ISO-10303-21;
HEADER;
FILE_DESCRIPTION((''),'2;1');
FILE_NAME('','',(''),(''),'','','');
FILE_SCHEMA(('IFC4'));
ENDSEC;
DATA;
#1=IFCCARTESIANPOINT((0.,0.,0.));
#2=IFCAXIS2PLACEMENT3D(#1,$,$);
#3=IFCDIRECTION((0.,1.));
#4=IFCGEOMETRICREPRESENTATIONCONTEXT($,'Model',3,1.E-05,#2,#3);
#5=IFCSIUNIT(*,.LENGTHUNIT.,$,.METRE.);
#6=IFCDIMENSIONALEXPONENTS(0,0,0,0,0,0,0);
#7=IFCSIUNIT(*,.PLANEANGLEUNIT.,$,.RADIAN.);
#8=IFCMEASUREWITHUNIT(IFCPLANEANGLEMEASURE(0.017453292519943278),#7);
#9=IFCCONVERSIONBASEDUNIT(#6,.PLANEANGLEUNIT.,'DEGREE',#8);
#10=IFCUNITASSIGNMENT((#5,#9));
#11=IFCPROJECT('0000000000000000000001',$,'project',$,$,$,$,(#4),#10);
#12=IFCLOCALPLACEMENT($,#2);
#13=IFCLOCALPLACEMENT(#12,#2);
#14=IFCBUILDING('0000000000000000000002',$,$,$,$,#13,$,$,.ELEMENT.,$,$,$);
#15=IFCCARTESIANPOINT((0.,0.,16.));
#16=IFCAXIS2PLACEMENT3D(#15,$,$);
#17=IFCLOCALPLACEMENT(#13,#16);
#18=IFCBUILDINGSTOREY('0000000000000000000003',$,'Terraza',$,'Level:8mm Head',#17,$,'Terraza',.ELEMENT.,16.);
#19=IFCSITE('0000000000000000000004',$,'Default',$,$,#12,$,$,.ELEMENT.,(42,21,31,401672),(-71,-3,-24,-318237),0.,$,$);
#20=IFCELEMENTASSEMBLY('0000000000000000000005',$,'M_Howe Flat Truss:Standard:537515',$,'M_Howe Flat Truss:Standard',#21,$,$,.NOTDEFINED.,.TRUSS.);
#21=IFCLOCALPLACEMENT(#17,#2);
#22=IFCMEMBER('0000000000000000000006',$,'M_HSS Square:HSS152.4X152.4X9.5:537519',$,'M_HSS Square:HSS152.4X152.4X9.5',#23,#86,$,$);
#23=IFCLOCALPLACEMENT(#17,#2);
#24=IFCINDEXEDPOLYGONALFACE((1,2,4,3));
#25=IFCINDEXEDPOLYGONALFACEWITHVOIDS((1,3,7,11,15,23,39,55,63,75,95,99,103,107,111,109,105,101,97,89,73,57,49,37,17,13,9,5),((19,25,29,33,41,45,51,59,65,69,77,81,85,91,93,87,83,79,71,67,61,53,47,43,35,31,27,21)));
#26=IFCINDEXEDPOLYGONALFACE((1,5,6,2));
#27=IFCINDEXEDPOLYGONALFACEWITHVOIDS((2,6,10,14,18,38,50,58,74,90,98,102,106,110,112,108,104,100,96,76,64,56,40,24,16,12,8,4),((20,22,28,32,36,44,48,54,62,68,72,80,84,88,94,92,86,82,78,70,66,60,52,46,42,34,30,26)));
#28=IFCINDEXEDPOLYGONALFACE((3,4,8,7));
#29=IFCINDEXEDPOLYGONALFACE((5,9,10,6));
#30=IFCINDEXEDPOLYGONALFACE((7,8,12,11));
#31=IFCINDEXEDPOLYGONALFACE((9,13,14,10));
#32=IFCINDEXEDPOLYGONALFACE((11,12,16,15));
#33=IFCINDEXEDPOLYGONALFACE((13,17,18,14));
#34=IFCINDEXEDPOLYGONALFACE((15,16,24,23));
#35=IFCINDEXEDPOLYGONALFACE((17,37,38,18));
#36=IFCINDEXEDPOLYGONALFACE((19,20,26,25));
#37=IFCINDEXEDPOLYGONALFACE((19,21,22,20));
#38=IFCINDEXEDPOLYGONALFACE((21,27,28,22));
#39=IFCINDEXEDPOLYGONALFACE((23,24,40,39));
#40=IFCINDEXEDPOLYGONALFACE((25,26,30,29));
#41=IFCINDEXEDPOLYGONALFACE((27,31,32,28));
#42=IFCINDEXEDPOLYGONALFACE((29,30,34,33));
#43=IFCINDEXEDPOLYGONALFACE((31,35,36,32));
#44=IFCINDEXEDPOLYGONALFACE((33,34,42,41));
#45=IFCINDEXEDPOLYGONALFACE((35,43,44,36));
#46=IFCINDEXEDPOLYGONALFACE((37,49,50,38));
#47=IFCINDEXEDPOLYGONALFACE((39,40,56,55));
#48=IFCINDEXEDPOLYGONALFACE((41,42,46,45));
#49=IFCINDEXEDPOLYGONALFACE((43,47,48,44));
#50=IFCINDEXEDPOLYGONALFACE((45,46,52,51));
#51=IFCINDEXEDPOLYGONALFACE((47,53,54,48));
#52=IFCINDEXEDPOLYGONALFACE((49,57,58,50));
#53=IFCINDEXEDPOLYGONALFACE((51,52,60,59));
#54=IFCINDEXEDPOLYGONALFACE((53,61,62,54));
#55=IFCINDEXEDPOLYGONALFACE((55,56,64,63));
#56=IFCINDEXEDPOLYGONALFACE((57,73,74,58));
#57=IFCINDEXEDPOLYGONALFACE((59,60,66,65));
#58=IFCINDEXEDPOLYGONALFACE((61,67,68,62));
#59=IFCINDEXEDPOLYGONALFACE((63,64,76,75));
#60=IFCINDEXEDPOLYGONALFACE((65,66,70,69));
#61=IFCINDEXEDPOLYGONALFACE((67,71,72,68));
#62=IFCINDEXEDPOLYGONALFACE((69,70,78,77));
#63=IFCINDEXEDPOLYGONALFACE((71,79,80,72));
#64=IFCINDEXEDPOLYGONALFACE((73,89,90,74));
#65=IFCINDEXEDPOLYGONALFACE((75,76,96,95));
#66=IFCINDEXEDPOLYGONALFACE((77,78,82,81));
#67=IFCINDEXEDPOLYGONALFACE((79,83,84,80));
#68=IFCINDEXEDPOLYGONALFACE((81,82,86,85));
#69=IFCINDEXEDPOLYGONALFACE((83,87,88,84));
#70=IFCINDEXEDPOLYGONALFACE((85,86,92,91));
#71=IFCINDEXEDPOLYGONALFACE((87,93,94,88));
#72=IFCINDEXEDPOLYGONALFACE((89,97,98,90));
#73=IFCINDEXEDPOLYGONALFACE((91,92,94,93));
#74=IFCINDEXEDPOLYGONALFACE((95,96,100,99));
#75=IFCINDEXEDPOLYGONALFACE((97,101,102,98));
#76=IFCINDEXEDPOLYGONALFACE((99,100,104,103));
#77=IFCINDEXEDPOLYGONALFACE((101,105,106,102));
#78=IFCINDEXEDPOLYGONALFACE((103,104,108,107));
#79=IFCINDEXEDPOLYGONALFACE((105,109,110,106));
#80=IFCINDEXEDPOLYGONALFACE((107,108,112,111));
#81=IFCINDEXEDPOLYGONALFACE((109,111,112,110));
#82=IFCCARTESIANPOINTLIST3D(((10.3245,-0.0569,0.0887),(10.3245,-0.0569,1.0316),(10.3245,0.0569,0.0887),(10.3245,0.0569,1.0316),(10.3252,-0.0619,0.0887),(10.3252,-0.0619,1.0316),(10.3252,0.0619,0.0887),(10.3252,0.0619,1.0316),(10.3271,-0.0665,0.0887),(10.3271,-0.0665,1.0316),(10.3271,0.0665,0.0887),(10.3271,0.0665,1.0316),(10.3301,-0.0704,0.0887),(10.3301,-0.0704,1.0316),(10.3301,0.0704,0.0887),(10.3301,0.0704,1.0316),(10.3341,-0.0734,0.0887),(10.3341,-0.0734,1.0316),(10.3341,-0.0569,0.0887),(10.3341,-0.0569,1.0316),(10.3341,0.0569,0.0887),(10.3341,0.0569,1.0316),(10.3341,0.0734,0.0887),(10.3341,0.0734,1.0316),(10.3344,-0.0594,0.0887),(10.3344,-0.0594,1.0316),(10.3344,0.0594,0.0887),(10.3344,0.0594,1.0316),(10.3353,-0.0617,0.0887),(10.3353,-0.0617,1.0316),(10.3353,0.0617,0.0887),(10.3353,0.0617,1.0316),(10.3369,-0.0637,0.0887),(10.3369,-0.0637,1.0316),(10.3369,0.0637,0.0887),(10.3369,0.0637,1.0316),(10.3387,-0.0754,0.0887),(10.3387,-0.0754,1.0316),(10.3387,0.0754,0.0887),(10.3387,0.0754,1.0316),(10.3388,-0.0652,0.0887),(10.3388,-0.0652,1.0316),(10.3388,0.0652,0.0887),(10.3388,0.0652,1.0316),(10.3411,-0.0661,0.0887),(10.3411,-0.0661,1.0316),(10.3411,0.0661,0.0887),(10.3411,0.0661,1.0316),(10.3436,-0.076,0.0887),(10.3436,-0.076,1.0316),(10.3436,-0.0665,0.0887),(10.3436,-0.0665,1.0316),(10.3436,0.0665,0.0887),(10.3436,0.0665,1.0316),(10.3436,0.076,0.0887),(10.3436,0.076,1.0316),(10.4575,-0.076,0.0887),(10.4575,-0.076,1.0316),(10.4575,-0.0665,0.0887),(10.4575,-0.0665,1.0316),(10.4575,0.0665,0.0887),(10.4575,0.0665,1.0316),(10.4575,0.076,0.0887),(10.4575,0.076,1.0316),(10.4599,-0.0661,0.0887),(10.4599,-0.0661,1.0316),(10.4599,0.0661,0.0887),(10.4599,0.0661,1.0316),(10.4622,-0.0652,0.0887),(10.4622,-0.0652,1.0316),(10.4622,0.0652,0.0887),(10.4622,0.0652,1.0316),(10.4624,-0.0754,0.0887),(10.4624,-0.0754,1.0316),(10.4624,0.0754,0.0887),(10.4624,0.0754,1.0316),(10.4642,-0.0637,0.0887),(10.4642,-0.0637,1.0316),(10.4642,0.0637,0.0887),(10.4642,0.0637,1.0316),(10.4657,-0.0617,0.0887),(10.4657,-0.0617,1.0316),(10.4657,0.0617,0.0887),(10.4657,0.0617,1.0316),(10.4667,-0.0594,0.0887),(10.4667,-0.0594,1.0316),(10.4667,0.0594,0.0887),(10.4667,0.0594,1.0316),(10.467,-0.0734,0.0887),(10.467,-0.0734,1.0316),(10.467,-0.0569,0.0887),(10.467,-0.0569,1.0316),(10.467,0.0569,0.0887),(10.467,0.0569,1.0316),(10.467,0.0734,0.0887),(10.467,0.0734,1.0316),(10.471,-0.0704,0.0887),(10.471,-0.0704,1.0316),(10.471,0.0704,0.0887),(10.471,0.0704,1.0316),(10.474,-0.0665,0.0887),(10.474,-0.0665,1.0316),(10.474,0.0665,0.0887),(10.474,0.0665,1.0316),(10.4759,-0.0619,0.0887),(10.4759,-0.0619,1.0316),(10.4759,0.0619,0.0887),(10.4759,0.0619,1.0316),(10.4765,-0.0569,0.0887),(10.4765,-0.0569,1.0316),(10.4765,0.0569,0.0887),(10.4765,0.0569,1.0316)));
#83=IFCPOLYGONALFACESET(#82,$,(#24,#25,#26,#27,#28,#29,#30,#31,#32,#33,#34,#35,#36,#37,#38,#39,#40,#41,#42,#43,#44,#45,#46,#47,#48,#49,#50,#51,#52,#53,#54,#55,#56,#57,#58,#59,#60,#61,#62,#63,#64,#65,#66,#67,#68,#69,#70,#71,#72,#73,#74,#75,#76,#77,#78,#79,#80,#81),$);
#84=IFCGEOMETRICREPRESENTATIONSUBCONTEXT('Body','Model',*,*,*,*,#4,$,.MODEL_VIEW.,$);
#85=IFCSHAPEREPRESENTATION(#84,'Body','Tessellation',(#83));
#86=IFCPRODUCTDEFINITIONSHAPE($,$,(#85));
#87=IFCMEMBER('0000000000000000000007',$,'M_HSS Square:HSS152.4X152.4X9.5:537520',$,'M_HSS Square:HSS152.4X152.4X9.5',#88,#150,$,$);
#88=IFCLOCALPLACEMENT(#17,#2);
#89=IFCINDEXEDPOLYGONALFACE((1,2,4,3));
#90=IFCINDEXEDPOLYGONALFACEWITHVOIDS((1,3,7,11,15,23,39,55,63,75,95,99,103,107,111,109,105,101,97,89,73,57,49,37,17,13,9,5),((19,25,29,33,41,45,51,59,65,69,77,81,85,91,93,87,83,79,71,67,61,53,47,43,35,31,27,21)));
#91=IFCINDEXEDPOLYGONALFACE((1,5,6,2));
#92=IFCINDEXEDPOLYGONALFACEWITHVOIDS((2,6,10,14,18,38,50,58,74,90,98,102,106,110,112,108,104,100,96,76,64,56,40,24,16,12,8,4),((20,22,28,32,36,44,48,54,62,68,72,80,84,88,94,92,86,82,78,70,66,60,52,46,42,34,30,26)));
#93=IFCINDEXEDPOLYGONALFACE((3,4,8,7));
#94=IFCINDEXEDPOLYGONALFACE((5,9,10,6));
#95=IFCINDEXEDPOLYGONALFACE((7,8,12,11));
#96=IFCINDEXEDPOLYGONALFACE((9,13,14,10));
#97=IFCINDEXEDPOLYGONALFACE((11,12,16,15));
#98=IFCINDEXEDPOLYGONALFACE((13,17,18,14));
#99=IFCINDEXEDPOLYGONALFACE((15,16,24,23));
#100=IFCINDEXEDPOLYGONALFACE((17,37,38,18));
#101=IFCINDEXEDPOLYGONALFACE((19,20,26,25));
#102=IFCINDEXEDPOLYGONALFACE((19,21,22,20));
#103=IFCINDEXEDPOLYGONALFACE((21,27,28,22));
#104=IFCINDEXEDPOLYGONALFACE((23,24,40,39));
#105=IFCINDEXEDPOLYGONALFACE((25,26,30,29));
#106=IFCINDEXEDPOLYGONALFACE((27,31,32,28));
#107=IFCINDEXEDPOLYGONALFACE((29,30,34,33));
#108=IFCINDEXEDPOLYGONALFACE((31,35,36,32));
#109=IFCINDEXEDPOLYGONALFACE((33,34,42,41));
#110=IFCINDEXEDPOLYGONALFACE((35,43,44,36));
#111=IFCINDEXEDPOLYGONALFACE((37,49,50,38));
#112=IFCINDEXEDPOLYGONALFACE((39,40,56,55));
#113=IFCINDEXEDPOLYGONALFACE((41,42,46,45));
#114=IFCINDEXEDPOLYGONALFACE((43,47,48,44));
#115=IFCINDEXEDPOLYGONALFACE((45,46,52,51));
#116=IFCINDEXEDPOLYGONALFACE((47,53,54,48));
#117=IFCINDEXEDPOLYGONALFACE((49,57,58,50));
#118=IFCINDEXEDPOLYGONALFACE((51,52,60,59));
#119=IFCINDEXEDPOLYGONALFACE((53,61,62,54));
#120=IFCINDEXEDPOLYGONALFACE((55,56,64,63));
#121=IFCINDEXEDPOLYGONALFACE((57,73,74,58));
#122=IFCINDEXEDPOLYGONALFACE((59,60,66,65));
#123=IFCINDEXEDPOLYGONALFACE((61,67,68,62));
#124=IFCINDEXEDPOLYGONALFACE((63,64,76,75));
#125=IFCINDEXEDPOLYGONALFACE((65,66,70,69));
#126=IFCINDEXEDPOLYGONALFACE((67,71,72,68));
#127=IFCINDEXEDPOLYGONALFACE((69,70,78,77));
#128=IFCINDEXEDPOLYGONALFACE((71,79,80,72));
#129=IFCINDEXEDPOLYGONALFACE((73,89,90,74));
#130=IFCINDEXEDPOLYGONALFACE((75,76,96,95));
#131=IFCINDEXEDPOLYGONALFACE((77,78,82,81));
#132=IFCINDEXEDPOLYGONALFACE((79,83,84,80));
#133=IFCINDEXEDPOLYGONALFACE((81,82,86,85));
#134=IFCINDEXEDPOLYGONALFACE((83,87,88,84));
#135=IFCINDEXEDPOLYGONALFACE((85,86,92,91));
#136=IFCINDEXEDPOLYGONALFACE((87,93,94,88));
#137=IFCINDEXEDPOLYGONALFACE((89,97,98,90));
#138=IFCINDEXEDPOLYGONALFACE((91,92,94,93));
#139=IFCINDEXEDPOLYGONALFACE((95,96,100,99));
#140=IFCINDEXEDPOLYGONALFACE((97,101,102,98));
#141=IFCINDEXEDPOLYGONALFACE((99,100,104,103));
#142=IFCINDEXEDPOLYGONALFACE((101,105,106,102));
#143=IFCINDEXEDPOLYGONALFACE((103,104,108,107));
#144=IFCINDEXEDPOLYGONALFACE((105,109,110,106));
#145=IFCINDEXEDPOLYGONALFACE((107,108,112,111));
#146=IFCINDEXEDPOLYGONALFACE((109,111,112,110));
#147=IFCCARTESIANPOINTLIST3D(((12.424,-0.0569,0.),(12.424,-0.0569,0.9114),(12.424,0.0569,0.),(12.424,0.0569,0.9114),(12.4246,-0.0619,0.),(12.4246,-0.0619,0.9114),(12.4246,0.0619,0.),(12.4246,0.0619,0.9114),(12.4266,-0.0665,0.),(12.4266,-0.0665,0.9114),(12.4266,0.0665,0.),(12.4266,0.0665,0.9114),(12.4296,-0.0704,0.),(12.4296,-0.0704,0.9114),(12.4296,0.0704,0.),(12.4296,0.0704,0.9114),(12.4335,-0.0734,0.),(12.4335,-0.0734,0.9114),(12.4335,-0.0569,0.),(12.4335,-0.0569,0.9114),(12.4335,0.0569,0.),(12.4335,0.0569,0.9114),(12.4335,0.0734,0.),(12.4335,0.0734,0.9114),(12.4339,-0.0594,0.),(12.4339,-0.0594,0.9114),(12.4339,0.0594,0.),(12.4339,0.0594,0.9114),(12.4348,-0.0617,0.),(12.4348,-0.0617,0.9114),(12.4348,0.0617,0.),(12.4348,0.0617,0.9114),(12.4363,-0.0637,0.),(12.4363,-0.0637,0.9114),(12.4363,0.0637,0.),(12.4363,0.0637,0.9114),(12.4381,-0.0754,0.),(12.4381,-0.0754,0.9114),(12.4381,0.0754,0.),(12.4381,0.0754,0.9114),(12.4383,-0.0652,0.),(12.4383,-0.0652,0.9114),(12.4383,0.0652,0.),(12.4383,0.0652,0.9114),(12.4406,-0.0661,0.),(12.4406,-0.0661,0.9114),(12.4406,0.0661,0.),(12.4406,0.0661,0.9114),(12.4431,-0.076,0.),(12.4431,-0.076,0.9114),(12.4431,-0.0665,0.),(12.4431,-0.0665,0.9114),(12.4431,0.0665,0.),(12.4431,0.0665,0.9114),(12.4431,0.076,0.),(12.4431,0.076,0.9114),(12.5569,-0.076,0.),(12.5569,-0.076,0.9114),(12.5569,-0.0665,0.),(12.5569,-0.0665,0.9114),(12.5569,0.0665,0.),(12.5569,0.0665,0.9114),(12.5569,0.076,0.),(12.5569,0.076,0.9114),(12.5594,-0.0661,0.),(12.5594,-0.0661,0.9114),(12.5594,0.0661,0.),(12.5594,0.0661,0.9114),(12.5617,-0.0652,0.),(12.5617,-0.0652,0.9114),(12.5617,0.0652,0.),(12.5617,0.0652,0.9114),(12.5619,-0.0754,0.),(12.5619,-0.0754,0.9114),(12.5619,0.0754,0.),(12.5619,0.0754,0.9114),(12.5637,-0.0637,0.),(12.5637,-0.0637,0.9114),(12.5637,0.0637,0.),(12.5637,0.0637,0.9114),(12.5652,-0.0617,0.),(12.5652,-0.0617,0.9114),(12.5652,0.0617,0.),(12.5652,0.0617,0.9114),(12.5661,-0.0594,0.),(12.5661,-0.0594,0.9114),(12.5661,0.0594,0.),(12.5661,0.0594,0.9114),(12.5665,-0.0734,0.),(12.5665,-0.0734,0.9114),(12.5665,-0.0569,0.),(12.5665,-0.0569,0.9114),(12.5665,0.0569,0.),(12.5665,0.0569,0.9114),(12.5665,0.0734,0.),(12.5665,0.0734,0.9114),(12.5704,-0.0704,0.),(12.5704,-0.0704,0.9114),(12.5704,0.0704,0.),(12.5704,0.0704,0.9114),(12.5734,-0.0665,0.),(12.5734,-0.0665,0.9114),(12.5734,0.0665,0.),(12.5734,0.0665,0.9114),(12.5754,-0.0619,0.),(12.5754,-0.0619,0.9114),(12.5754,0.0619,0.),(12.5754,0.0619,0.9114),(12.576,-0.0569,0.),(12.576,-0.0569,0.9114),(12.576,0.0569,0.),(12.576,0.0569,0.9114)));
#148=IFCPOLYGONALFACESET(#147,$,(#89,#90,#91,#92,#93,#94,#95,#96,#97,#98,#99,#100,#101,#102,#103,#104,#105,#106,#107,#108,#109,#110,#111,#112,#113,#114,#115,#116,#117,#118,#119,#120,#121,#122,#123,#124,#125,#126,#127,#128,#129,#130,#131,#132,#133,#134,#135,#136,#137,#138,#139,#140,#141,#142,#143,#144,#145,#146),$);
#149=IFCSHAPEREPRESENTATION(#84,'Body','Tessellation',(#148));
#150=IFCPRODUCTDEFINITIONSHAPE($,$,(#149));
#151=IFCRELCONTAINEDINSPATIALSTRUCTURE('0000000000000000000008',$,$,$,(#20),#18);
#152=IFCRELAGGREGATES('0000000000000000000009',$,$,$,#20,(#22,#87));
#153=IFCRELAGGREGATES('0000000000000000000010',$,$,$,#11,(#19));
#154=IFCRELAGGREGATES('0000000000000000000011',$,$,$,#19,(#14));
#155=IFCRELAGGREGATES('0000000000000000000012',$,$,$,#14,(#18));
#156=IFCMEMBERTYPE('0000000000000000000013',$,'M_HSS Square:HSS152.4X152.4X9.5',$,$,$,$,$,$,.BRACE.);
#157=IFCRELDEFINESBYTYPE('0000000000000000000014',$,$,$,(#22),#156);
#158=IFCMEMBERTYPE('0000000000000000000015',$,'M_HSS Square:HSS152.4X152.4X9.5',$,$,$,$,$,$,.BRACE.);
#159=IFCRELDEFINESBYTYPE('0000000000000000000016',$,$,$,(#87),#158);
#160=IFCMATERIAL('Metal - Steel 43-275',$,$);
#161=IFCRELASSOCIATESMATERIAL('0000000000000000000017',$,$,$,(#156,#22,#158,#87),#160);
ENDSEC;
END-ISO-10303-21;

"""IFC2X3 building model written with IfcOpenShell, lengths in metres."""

from ifc_helpers import new_model, entity, si_unit, converted_unit, direction, frame, frame_2d, origin, place, context, subcontext, project, spatial, polyline, circle_curve, parameter, trimmed, segment, composite_curve, outline, extrude, source, transform, mapped, material, type_object, type_shapes, element, aggregate, save


model = new_model("IFC2X3")

# Units and contexts
model_context = context("Model", 3, precision=1e-05, world=origin(), true_north=direction((0.0, 1.0)))
body_context = subcontext(model_context, "Body", "Model", "MODEL_VIEW")
ifc_project = project(units=[si_unit("LENGTHUNIT", "METRE"), converted_unit("PLANEANGLEUNIT", "DEGREE", entity("IfcPlaneAngleMeasure", 0.017453292519943278), si_unit("PLANEANGLEUNIT", "RADIAN"), dimensions=[0, 0, 0, 0, 0, 0, 0])], contexts=[model_context])

# Site, building, storey
site_placement = place(None, origin())
site = spatial("IfcSite", under=ifc_project, at=site_placement, Name="Default", CompositionType="ELEMENT", RefLatitude=(42, 21, 31, 401672), RefLongitude=(-71, -3, -24, -318237), RefElevation=0.0)
building_placement = place(site_placement, origin())
building = spatial("IfcBuilding", under=site, at=building_placement, CompositionType="ELEMENT")
storey_placement = place(building_placement, frame((0.0, 0.0, 16.0)))
storey = spatial("IfcBuildingStorey", under=building, at=storey_placement, Name="Terraza", ObjectType="Level:8mm Head", LongName="Terraza", CompositionType="ELEMENT", Elevation=16.0)

# Element assembly
assembly_1_placement = place(storey_placement, origin())
assembly_1 = element("IfcElementAssembly", 1, at=assembly_1_placement, inside=storey, Name="M_Howe Flat Truss:Standard:537515", ObjectType="M_Howe Flat Truss:Standard", AssemblyPlace="NOTDEFINED", PredefinedType="TRUSS")
ifc_material_1 = material(Name="Metal - Steel 43-275")

# Members
member_type_1 = type_object("IfcMemberType", Name="M_HSS Square:HSS152.4X152.4X9.5", PredefinedType="BRACE", material=ifc_material_1)
shared_shape_1 = source(origin(), body_context, "Body", "SweptSolid", [
    extrude(outline(composite_curve([segment(polyline([(-0.0569, -0.076), (0.0569, -0.076)]), True, "CONTINUOUS"), segment(trimmed(circle_curve(frame_2d((0.0569, -0.0569), x_axis=(0.0, 1.0)), 0.0191), [parameter(180.0)], [parameter(270.0)], True, "PARAMETER"), True, "CONTINUOUS"), segment(polyline([(0.076, -0.0569), (0.076, 0.0569)]), True, "CONTINUOUS"), segment(trimmed(circle_curve(frame_2d((0.0569, 0.0569), x_axis=(0.0, 1.0)), 0.0191), [parameter(270.0)], [parameter(0.0)], True, "PARAMETER"), True, "CONTINUOUS"), segment(polyline([(0.0569, 0.076), (-0.0569, 0.076)]), True, "CONTINUOUS"), segment(trimmed(circle_curve(frame_2d((-0.0569, 0.0569), x_axis=(0.0, 1.0)), 0.0191), [parameter(0.0)], [parameter(90.0)], True, "PARAMETER"), True, "CONTINUOUS"), segment(polyline([(-0.076, 0.0569), (-0.076, -0.0569)]), True, "CONTINUOUS"), segment(trimmed(circle_curve(frame_2d((-0.0569, -0.0569), x_axis=(0.0, 1.0)), 0.0191), [parameter(90.0)], [parameter(180.0)], True, "PARAMETER"), True, "CONTINUOUS")], self_intersect=False), holes=[composite_curve([segment(trimmed(circle_curve(frame_2d((-0.0569, 0.0569), x_axis=(0.0, 1.0)), 0.0095), [parameter(360.0)], [parameter(90.0)], True, "PARAMETER"), False, "CONTINUOUS"), segment(polyline([(-0.0569, 0.0665), (0.0569, 0.0665)]), True, "CONTINUOUS"), segment(trimmed(circle_curve(frame_2d((0.0569, 0.0569), x_axis=(0.0, 1.0)), 0.0095), [parameter(270.0)], [parameter(360.0)], True, "PARAMETER"), False, "CONTINUOUS"), segment(polyline([(0.0665, 0.0569), (0.0665, -0.0569)]), True, "CONTINUOUS"), segment(trimmed(circle_curve(frame_2d((0.0569, -0.0569), x_axis=(0.0, 1.0)), 0.0095), [parameter(180.0)], [parameter(270.0)], True, "PARAMETER"), False, "CONTINUOUS"), segment(polyline([(0.0569, -0.0665), (-0.0569, -0.0665)]), True, "CONTINUOUS"), segment(trimmed(circle_curve(frame_2d((-0.0569, -0.0569), x_axis=(0.0, 1.0)), 0.0095), [parameter(90.0)], [parameter(180.0)], True, "PARAMETER"), False, "CONTINUOUS"), segment(polyline([(-0.0665, -0.0569), (-0.0665, 0.0569)]), True, "CONTINUOUS")], self_intersect=False)]), frame((-0.4738, 0.0, 0.0), z_axis=(1.0, 0.0, 0.0), x_axis=(0.0, 0.0, -1.0)), (0.0, 0.0, 1.0), 0.9429),
])
type_shapes(member_type_1, [shared_shape_1])
member_1_placement = place(assembly_1_placement, frame((10.4005, 0.0, 0.5625), z_axis=(1.0, 0.0, 0.0), x_axis=(0.0, 0.0, 1.0)))
member_1 = element("IfcMember", 2, at=member_1_placement, type_object=member_type_1, material=ifc_material_1, Name="M_HSS Square:HSS152.4X152.4X9.5:537519", ObjectType="M_HSS Square:HSS152.4X152.4X9.5", context=body_context, shape_type="MappedRepresentation", body=[
    mapped(shared_shape_1, transform((0.0, 0.0, 0.0), scale=1.0)),
])
member_type_2 = type_object("IfcMemberType", Name="M_HSS Square:HSS152.4X152.4X9.5", PredefinedType="BRACE", material=ifc_material_1)
shared_shape_2 = source(origin(), body_context, "Body", "SweptSolid", [
    extrude(outline(composite_curve([segment(polyline([(-0.0569, -0.076), (0.0569, -0.076)]), True, "CONTINUOUS"), segment(trimmed(circle_curve(frame_2d((0.0569, -0.0569), x_axis=(0.0, 1.0)), 0.0191), [parameter(180.0)], [parameter(270.0)], True, "PARAMETER"), True, "CONTINUOUS"), segment(polyline([(0.076, -0.0569), (0.076, 0.0569)]), True, "CONTINUOUS"), segment(trimmed(circle_curve(frame_2d((0.0569, 0.0569), x_axis=(0.0, 1.0)), 0.0191), [parameter(270.0)], [parameter(0.0)], True, "PARAMETER"), True, "CONTINUOUS"), segment(polyline([(0.0569, 0.076), (-0.0569, 0.076)]), True, "CONTINUOUS"), segment(trimmed(circle_curve(frame_2d((-0.0569, 0.0569), x_axis=(0.0, 1.0)), 0.0191), [parameter(0.0)], [parameter(90.0)], True, "PARAMETER"), True, "CONTINUOUS"), segment(polyline([(-0.076, 0.0569), (-0.076, -0.0569)]), True, "CONTINUOUS"), segment(trimmed(circle_curve(frame_2d((-0.0569, -0.0569), x_axis=(0.0, 1.0)), 0.0191), [parameter(90.0)], [parameter(180.0)], True, "PARAMETER"), True, "CONTINUOUS")], self_intersect=False), holes=[composite_curve([segment(trimmed(circle_curve(frame_2d((-0.0569, 0.0569), x_axis=(0.0, 1.0)), 0.0095), [parameter(360.0)], [parameter(90.0)], True, "PARAMETER"), False, "CONTINUOUS"), segment(polyline([(-0.0569, 0.0665), (0.0569, 0.0665)]), True, "CONTINUOUS"), segment(trimmed(circle_curve(frame_2d((0.0569, 0.0569), x_axis=(0.0, 1.0)), 0.0095), [parameter(270.0)], [parameter(360.0)], True, "PARAMETER"), False, "CONTINUOUS"), segment(polyline([(0.0665, 0.0569), (0.0665, -0.0569)]), True, "CONTINUOUS"), segment(trimmed(circle_curve(frame_2d((0.0569, -0.0569), x_axis=(0.0, 1.0)), 0.0095), [parameter(180.0)], [parameter(270.0)], True, "PARAMETER"), False, "CONTINUOUS"), segment(polyline([(0.0569, -0.0665), (-0.0569, -0.0665)]), True, "CONTINUOUS"), segment(trimmed(circle_curve(frame_2d((-0.0569, -0.0569), x_axis=(0.0, 1.0)), 0.0095), [parameter(90.0)], [parameter(180.0)], True, "PARAMETER"), False, "CONTINUOUS"), segment(polyline([(-0.0665, -0.0569), (-0.0665, 0.0569)]), True, "CONTINUOUS")], self_intersect=False)]), frame((-0.5, 0.0, 0.0), z_axis=(1.0, 0.0, 0.0), x_axis=(0.0, 0.0, -1.0)), (0.0, 0.0, 1.0), 0.9114),
])
type_shapes(member_type_2, [shared_shape_2])
member_2_placement = place(assembly_1_placement, frame((12.5, 0.0, 0.5), z_axis=(1.0, 0.0, 0.0), x_axis=(0.0, 0.0, 1.0)))
member_2 = element("IfcMember", 3, at=member_2_placement, type_object=member_type_2, material=ifc_material_1, Name="M_HSS Square:HSS152.4X152.4X9.5:537520", ObjectType="M_HSS Square:HSS152.4X152.4X9.5", context=body_context, shape_type="MappedRepresentation", body=[
    mapped(shared_shape_2, transform((0.0, 0.0, 0.0), scale=1.0)),
])
aggregate(assembly_1, [member_1, member_2])

save(model, "model.ifc")
